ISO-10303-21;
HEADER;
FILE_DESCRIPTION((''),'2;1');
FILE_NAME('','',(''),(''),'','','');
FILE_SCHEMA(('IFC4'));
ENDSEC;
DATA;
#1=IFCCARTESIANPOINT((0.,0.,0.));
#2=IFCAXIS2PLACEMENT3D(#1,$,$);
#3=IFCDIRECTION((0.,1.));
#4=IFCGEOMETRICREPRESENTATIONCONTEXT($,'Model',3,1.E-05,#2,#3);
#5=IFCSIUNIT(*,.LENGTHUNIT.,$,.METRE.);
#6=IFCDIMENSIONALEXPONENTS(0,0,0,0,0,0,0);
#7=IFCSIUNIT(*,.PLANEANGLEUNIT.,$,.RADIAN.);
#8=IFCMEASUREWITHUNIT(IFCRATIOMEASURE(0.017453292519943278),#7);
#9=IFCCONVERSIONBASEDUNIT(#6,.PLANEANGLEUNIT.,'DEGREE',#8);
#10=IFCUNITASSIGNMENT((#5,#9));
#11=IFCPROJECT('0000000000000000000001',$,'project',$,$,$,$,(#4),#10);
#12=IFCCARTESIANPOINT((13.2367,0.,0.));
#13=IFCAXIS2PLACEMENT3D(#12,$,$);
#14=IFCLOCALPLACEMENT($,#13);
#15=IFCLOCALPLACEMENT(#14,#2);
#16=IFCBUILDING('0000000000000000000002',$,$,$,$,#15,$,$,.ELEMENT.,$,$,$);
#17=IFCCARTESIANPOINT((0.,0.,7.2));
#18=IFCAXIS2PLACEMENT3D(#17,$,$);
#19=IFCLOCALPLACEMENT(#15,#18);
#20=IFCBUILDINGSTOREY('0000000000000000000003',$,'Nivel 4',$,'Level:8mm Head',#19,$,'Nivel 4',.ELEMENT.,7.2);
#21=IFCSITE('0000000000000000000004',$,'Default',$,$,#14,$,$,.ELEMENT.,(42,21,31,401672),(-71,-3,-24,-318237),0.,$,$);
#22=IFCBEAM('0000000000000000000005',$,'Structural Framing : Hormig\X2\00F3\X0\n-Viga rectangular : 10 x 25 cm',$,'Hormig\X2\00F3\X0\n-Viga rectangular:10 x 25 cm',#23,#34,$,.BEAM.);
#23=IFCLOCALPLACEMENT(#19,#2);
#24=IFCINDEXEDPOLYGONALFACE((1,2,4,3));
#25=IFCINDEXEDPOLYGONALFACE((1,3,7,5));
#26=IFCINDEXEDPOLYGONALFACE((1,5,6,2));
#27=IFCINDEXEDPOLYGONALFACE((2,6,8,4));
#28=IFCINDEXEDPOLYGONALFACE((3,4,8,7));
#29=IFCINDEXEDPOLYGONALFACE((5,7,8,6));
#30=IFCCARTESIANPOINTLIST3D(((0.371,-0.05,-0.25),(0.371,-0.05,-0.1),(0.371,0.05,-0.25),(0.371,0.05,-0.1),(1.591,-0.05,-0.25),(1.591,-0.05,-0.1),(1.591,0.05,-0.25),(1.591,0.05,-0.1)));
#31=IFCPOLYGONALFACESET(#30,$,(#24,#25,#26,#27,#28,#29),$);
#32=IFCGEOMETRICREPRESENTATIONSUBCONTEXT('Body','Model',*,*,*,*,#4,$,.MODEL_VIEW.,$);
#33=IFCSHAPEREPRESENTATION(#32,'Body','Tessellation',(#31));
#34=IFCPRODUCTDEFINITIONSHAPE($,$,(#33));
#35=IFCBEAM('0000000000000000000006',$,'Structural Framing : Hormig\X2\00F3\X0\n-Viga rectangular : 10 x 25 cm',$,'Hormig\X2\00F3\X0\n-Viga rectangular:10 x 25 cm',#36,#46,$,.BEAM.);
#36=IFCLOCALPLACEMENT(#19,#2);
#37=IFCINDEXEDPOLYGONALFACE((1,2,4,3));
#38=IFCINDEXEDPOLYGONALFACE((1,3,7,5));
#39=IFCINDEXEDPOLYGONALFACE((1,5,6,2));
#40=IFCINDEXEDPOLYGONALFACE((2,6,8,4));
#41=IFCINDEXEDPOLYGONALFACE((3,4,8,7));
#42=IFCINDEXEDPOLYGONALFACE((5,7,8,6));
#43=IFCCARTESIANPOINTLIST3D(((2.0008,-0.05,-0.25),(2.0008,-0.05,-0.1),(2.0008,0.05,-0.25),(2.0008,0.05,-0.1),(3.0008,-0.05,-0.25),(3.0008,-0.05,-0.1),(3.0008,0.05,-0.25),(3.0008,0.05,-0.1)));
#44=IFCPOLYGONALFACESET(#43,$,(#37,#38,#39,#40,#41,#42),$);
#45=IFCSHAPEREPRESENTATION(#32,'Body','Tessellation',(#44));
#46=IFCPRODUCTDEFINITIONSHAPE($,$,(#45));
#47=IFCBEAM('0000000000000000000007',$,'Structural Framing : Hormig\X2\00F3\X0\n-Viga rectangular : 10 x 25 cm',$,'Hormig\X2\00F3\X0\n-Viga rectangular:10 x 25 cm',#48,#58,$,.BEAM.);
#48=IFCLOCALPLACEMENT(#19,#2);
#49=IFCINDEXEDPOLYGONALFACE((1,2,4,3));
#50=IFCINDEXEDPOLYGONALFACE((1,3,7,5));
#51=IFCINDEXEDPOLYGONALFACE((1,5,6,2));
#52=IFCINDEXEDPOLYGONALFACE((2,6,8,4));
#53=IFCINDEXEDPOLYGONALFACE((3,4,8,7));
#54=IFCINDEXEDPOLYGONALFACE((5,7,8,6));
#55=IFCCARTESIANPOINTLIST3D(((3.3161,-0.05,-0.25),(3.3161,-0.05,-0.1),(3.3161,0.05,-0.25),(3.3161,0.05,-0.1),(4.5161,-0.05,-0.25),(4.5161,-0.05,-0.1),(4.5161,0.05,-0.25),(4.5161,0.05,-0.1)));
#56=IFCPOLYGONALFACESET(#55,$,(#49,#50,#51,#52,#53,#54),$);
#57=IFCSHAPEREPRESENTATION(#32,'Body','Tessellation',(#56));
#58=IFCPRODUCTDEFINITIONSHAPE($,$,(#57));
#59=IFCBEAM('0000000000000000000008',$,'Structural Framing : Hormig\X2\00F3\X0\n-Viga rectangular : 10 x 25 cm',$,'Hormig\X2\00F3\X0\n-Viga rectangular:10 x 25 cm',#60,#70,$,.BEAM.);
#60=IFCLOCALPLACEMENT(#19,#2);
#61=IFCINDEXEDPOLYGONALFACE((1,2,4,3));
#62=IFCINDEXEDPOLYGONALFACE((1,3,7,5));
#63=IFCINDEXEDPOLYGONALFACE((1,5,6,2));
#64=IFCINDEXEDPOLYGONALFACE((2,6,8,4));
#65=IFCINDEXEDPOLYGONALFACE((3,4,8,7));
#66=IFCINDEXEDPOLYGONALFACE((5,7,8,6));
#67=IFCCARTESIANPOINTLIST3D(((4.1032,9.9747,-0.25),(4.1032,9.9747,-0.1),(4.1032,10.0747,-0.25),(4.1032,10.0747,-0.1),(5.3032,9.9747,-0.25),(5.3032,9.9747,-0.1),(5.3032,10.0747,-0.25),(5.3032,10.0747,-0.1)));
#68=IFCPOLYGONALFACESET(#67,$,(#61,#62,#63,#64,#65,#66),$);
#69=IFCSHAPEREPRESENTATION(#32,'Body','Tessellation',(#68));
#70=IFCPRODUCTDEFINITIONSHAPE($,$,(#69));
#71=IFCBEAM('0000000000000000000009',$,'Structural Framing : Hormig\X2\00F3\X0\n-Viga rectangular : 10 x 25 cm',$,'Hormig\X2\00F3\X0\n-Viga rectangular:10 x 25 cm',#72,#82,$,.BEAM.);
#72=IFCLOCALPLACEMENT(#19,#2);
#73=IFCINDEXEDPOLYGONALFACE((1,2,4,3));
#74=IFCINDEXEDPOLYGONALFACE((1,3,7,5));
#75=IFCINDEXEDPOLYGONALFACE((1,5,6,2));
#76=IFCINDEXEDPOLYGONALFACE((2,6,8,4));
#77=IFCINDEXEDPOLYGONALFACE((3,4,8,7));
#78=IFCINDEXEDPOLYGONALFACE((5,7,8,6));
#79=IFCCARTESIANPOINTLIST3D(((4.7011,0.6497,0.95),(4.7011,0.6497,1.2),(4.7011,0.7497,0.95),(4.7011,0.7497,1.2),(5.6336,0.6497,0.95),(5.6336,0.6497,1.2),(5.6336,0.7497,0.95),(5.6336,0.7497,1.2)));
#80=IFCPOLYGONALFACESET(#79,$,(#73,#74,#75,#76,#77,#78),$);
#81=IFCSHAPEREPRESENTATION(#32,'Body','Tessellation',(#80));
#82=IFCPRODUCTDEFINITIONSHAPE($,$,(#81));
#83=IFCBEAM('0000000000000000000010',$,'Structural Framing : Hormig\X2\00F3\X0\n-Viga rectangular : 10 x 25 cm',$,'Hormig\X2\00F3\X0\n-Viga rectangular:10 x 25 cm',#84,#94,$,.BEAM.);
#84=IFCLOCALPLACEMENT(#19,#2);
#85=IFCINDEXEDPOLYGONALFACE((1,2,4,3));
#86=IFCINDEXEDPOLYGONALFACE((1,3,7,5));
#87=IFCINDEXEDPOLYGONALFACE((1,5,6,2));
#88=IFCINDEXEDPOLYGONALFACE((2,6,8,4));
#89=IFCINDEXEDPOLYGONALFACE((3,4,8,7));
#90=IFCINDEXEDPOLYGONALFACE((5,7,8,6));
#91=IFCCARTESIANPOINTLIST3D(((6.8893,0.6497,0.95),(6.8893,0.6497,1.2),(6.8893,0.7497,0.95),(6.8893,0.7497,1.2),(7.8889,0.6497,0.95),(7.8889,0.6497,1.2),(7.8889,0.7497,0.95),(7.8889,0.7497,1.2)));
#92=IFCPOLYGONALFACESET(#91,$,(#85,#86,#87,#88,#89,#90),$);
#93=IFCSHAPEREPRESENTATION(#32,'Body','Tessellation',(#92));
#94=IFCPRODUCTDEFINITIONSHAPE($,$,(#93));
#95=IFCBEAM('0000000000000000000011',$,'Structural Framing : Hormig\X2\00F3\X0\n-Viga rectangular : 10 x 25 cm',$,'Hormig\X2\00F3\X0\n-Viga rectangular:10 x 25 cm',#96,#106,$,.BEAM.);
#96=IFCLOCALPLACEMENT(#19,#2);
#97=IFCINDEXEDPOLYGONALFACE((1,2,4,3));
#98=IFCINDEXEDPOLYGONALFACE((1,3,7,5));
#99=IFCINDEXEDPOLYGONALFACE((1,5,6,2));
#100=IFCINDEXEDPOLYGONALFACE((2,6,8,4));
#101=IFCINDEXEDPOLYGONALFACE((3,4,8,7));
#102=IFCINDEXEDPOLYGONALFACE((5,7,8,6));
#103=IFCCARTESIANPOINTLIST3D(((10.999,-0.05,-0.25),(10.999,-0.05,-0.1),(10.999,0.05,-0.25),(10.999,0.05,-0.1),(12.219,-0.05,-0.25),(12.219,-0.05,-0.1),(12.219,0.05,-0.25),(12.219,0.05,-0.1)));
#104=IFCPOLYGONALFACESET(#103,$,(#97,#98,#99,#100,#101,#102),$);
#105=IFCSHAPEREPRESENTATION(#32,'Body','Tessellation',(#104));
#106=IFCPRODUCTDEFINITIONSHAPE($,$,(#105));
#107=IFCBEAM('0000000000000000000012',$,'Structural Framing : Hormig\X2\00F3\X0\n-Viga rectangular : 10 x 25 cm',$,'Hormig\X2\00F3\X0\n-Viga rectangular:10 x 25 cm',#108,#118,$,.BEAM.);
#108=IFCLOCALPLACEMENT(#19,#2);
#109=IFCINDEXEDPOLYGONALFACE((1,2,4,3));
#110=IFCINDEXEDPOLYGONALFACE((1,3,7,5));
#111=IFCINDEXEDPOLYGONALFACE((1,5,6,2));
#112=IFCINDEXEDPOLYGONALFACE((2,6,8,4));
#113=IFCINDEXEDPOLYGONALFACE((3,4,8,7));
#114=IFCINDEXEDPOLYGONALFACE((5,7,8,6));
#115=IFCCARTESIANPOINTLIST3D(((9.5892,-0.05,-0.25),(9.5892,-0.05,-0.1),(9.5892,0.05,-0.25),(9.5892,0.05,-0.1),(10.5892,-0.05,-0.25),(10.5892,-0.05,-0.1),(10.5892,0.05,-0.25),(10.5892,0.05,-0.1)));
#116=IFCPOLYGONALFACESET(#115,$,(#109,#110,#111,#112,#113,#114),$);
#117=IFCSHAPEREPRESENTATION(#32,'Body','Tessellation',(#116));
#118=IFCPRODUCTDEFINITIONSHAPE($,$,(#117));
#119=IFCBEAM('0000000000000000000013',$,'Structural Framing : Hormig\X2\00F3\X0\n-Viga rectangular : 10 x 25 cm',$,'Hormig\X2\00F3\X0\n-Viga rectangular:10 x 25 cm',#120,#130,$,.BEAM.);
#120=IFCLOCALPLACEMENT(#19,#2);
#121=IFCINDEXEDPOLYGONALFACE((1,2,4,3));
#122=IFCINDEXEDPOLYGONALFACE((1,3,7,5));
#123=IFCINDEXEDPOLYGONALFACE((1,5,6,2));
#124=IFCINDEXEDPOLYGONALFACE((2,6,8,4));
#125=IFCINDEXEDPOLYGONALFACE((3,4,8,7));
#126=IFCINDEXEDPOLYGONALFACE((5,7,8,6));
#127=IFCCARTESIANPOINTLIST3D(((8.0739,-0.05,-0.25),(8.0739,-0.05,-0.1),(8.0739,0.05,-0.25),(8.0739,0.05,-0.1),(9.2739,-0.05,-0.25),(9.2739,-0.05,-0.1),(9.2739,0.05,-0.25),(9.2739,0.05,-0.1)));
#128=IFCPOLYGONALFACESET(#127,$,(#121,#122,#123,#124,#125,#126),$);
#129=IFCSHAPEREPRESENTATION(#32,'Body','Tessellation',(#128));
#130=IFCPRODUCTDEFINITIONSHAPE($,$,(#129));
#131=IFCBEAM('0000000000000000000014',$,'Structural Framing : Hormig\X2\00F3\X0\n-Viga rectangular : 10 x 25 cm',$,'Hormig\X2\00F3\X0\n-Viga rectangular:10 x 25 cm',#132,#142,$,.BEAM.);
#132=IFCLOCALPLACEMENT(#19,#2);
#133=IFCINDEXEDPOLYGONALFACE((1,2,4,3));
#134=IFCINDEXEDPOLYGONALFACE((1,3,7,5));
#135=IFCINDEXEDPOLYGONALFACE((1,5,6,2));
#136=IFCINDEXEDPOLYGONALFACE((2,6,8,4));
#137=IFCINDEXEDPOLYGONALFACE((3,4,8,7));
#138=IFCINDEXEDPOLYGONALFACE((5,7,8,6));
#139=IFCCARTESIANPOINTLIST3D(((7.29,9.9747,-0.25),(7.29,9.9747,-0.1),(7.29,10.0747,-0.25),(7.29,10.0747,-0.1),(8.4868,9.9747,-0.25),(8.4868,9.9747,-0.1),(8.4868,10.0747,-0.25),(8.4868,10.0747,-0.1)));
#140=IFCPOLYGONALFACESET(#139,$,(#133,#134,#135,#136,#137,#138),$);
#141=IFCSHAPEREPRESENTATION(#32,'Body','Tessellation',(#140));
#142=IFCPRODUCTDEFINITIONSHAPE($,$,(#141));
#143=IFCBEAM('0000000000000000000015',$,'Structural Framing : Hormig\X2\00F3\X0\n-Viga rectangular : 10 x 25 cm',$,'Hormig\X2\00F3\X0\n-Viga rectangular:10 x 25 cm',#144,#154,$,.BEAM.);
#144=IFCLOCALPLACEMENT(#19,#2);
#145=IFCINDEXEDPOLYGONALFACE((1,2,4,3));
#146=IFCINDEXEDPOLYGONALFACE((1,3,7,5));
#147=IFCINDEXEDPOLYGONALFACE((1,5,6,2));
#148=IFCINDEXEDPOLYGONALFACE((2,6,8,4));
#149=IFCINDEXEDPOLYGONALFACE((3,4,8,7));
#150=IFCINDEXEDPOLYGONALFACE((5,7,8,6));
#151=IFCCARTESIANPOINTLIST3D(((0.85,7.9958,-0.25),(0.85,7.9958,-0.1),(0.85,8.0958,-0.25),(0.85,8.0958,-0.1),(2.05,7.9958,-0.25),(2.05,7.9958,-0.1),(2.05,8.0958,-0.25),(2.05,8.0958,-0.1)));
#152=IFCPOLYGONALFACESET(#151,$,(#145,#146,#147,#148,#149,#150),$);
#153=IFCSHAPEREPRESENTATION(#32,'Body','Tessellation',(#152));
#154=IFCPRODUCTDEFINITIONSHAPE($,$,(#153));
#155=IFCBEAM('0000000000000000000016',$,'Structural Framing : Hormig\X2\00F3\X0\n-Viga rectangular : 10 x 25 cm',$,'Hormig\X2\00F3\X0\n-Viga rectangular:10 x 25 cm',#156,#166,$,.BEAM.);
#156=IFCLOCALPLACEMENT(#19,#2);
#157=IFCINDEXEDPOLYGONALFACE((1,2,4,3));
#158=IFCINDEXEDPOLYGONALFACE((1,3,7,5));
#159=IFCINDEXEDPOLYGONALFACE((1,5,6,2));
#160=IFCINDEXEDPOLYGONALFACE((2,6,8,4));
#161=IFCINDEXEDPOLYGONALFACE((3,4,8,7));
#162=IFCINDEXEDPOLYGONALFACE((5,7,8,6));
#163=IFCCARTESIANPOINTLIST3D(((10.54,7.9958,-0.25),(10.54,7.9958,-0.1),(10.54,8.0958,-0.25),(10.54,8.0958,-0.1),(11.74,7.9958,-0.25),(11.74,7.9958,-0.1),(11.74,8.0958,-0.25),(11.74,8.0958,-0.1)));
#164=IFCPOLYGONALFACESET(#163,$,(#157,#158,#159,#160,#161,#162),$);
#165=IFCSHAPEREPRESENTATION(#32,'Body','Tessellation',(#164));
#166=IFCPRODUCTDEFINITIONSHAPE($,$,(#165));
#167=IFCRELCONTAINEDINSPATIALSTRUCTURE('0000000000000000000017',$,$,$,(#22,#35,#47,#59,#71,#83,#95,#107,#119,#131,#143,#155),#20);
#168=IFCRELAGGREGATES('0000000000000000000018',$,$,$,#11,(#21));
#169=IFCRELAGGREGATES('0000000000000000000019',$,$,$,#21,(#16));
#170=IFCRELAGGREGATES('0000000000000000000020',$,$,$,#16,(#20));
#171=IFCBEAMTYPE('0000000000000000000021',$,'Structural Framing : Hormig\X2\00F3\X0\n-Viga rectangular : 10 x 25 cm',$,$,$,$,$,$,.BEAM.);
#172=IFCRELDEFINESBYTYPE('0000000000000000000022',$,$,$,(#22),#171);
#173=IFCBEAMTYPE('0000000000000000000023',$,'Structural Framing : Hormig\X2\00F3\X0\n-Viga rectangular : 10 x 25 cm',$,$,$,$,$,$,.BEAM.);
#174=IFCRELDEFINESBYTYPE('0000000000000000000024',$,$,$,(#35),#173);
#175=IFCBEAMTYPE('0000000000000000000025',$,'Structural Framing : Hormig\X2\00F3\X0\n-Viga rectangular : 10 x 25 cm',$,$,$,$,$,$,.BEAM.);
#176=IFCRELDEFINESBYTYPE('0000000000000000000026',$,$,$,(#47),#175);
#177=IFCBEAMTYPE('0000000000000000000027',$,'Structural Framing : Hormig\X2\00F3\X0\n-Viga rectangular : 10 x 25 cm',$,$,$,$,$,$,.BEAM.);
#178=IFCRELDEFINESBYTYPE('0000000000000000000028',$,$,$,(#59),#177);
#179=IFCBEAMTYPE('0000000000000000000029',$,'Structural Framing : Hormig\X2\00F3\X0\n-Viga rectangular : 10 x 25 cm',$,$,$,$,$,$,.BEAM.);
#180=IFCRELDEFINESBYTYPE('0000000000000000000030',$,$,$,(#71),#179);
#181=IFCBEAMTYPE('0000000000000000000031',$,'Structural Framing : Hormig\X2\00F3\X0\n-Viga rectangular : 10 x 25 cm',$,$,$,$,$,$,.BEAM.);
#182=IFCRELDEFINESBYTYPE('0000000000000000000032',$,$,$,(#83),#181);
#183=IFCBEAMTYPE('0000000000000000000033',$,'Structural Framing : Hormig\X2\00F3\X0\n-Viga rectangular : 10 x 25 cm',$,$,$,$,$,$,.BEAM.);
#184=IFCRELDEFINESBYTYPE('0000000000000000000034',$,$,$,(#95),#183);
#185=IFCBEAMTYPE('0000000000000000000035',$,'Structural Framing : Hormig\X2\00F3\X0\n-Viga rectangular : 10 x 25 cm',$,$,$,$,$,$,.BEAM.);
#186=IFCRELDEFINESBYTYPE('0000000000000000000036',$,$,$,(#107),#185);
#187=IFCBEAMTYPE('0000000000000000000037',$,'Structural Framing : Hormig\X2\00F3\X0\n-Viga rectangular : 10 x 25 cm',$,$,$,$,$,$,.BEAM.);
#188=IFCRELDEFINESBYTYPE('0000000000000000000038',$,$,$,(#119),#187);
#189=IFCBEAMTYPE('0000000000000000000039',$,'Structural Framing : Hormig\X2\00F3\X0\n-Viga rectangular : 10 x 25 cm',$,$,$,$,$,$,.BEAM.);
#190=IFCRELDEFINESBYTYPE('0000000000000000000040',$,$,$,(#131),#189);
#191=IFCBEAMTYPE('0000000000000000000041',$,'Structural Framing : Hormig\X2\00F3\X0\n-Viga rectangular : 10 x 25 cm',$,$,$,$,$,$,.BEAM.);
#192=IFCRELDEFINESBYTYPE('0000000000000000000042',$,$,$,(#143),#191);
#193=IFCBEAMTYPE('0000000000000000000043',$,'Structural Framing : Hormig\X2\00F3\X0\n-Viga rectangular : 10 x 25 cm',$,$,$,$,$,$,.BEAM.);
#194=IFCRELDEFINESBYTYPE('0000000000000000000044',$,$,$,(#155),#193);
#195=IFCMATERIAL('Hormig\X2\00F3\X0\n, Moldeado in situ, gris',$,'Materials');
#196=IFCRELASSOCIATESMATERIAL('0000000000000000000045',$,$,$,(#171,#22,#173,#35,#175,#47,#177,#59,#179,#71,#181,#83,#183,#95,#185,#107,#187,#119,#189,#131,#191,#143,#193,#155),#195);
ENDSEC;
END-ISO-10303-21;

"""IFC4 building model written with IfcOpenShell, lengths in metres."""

from ifc_helpers import new_model, entity, si_unit, converted_unit, direction, frame, origin, place, context, subcontext, project, spatial, indexed_curve, outline, extrude, source, transform, mapped, material, type_object, type_shapes, element, save


model = new_model("IFC4")

# Units and contexts
model_context = context("Model", 3, precision=1e-05, world=origin(), true_north=direction((0.0, 1.0)))
body_context = subcontext(model_context, "Body", "Model", "MODEL_VIEW")
ifc_project = project(units=[si_unit("LENGTHUNIT", "METRE"), converted_unit("PLANEANGLEUNIT", "DEGREE", entity("IfcRatioMeasure", 0.017453292519943278), si_unit("PLANEANGLEUNIT", "RADIAN"), dimensions=[0, 0, 0, 0, 0, 0, 0])], contexts=[model_context])

# Site, building, storey
site_placement = place(None, frame((13.2367, 0.0, 0.0)))
site = spatial("IfcSite", under=ifc_project, at=site_placement, Name="Default", CompositionType="ELEMENT", RefLatitude=(42, 21, 31, 401672), RefLongitude=(-71, -3, -24, -318237), RefElevation=0.0)
building_placement = place(site_placement, origin())
building = spatial("IfcBuilding", under=site, at=building_placement, CompositionType="ELEMENT")
storey_placement = place(building_placement, frame((0.0, 0.0, 7.2)))
storey = spatial("IfcBuildingStorey", under=building, at=storey_placement, Name="Nivel 4", ObjectType="Level:8mm Head", LongName="Nivel 4", CompositionType="ELEMENT", Elevation=7.2)

# Beams
ifc_material_1 = material(Name="Hormigón, Moldeado in situ, gris", Category="Materials")
beam_type_1 = type_object("IfcBeamType", Name="Structural Framing : Hormigón-Viga rectangular : 10 x 25 cm", PredefinedType="BEAM", material=ifc_material_1)
shared_shape_1 = source(origin(), body_context, "Body", "SweptSolid", [
    extrude(outline(indexed_curve([(-0.075, -0.05), (0.075, -0.05), (0.075, 0.05), (-0.075, 0.05), (-0.075, -0.05)], self_intersect=False)), frame((0.371, 0.0, 7.025), z_axis=(1.0, 0.0, 0.0), x_axis=(0.0, 0.0, -1.0)), (0.0, 0.0, 1.0), 1.22),
])
type_shapes(beam_type_1, [shared_shape_1])
beam_1_placement = place(storey_placement, frame((0.0, 0.0, -7.2)))
element("IfcBeam", 1, at=beam_1_placement, inside=storey, type_object=beam_type_1, material=ifc_material_1, Name="Structural Framing : Hormigón-Viga rectangular : 10 x 25 cm", ObjectType="Hormigón-Viga rectangular:10 x 25 cm", PredefinedType="BEAM", context=body_context, shape_type="MappedRepresentation", body=[
    mapped(shared_shape_1, transform((0.0, 0.0, 0.0), scale=1.0)),
])
beam_type_2 = type_object("IfcBeamType", Name="Structural Framing : Hormigón-Viga rectangular : 10 x 25 cm", PredefinedType="BEAM", material=ifc_material_1)
shared_shape_2 = source(origin(), body_context, "Body", "SweptSolid", [
    extrude(outline(indexed_curve([(-0.075, -0.05), (0.075, -0.05), (0.075, 0.05), (-0.075, 0.05), (-0.075, -0.05)], self_intersect=False)), frame((2.0008, 0.0, 7.025), z_axis=(1.0, 0.0, 0.0), x_axis=(0.0, 0.0, -1.0)), (0.0, 0.0, 1.0), 1.0),
])
type_shapes(beam_type_2, [shared_shape_2])
beam_2_placement = place(storey_placement, frame((0.0, 0.0, -7.2)))
element("IfcBeam", 2, at=beam_2_placement, inside=storey, type_object=beam_type_2, material=ifc_material_1, Name="Structural Framing : Hormigón-Viga rectangular : 10 x 25 cm", ObjectType="Hormigón-Viga rectangular:10 x 25 cm", PredefinedType="BEAM", context=body_context, shape_type="MappedRepresentation", body=[
    mapped(shared_shape_2, transform((0.0, 0.0, 0.0), scale=1.0)),
])
beam_type_3 = type_object("IfcBeamType", Name="Structural Framing : Hormigón-Viga rectangular : 10 x 25 cm", PredefinedType="BEAM", material=ifc_material_1)
shared_shape_3 = source(origin(), body_context, "Body", "SweptSolid", [
    extrude(outline(indexed_curve([(-0.075, -0.05), (0.075, -0.05), (0.075, 0.05), (-0.075, 0.05), (-0.075, -0.05)], self_intersect=False)), frame((3.3161, 0.0, 7.025), z_axis=(1.0, 0.0, 0.0), x_axis=(0.0, 0.0, -1.0)), (0.0, 0.0, 1.0), 1.2),
])
type_shapes(beam_type_3, [shared_shape_3])
beam_3_placement = place(storey_placement, frame((0.0, 0.0, -7.2)))
element("IfcBeam", 3, at=beam_3_placement, inside=storey, type_object=beam_type_3, material=ifc_material_1, Name="Structural Framing : Hormigón-Viga rectangular : 10 x 25 cm", ObjectType="Hormigón-Viga rectangular:10 x 25 cm", PredefinedType="BEAM", context=body_context, shape_type="MappedRepresentation", body=[
    mapped(shared_shape_3, transform((0.0, 0.0, 0.0), scale=1.0)),
])
beam_type_4 = type_object("IfcBeamType", Name="Structural Framing : Hormigón-Viga rectangular : 10 x 25 cm", PredefinedType="BEAM", material=ifc_material_1)
shared_shape_4 = source(origin(), body_context, "Body", "SweptSolid", [
    extrude(outline(indexed_curve([(-0.075, -0.05), (0.075, -0.05), (0.075, 0.05), (-0.075, 0.05), (-0.075, -0.05)], self_intersect=False)), frame((5.3032, 10.0247, 7.025), z_axis=(-1.0, 0.0, 0.0), x_axis=(0.0, 0.0, -1.0)), (0.0, 0.0, 1.0), 1.2),
])
type_shapes(beam_type_4, [shared_shape_4])
beam_4_placement = place(storey_placement, frame((0.0, 0.0, -7.2)))
element("IfcBeam", 4, at=beam_4_placement, inside=storey, type_object=beam_type_4, material=ifc_material_1, Name="Structural Framing : Hormigón-Viga rectangular : 10 x 25 cm", ObjectType="Hormigón-Viga rectangular:10 x 25 cm", PredefinedType="BEAM", context=body_context, shape_type="MappedRepresentation", body=[
    mapped(shared_shape_4, transform((0.0, 0.0, 0.0), scale=1.0)),
])
beam_type_5 = type_object("IfcBeamType", Name="Structural Framing : Hormigón-Viga rectangular : 10 x 25 cm", PredefinedType="BEAM", material=ifc_material_1)
shared_shape_5 = source(origin(), body_context, "Body", "SweptSolid", [
    extrude(outline(indexed_curve([(-0.125, -0.05), (0.125, -0.05), (0.125, 0.05), (-0.125, 0.05), (-0.125, -0.05)], self_intersect=False)), frame((5.6336, 0.6997, 8.275), z_axis=(-1.0, 0.0, 0.0), x_axis=(0.0, 0.0, -1.0)), (0.0, 0.0, 1.0), 0.9325),
])
type_shapes(beam_type_5, [shared_shape_5])
beam_5_placement = place(storey_placement, frame((0.0, 0.0, -7.2)))
element("IfcBeam", 5, at=beam_5_placement, inside=storey, type_object=beam_type_5, material=ifc_material_1, Name="Structural Framing : Hormigón-Viga rectangular : 10 x 25 cm", ObjectType="Hormigón-Viga rectangular:10 x 25 cm", PredefinedType="BEAM", context=body_context, shape_type="MappedRepresentation", body=[
    mapped(shared_shape_5, transform((0.0, 0.0, 0.0), scale=1.0)),
])
beam_type_6 = type_object("IfcBeamType", Name="Structural Framing : Hormigón-Viga rectangular : 10 x 25 cm", PredefinedType="BEAM", material=ifc_material_1)
shared_shape_6 = source(origin(), body_context, "Body", "SweptSolid", [
    extrude(outline(indexed_curve([(-0.125, -0.05), (0.125, -0.05), (0.125, 0.05), (-0.125, 0.05), (-0.125, -0.05)], self_intersect=False)), frame((7.8889, 0.6997, 8.275), z_axis=(-1.0, 0.0, 0.0), x_axis=(0.0, 0.0, -1.0)), (0.0, 0.0, 1.0), 0.9996),
])
type_shapes(beam_type_6, [shared_shape_6])
beam_6_placement = place(storey_placement, frame((0.0, 0.0, -7.2)))
element("IfcBeam", 6, at=beam_6_placement, inside=storey, type_object=beam_type_6, material=ifc_material_1, Name="Structural Framing : Hormigón-Viga rectangular : 10 x 25 cm", ObjectType="Hormigón-Viga rectangular:10 x 25 cm", PredefinedType="BEAM", context=body_context, shape_type="MappedRepresentation", body=[
    mapped(shared_shape_6, transform((0.0, 0.0, 0.0), scale=1.0)),
])
beam_type_7 = type_object("IfcBeamType", Name="Structural Framing : Hormigón-Viga rectangular : 10 x 25 cm", PredefinedType="BEAM", material=ifc_material_1)
shared_shape_7 = source(origin(), body_context, "Body", "SweptSolid", [
    extrude(outline(indexed_curve([(-0.075, -0.05), (0.075, -0.05), (0.075, 0.05), (-0.075, 0.05), (-0.075, -0.05)], self_intersect=False)), frame((12.219, 0.0, 7.025), z_axis=(-1.0, 0.0, 0.0), x_axis=(0.0, 0.0, -1.0)), (0.0, 0.0, 1.0), 1.22),
])
type_shapes(beam_type_7, [shared_shape_7])
beam_7_placement = place(storey_placement, frame((0.0, 0.0, -7.2)))
element("IfcBeam", 7, at=beam_7_placement, inside=storey, type_object=beam_type_7, material=ifc_material_1, Name="Structural Framing : Hormigón-Viga rectangular : 10 x 25 cm", ObjectType="Hormigón-Viga rectangular:10 x 25 cm", PredefinedType="BEAM", context=body_context, shape_type="MappedRepresentation", body=[
    mapped(shared_shape_7, transform((0.0, 0.0, 0.0), scale=1.0)),
])
beam_type_8 = type_object("IfcBeamType", Name="Structural Framing : Hormigón-Viga rectangular : 10 x 25 cm", PredefinedType="BEAM", material=ifc_material_1)
shared_shape_8 = source(origin(), body_context, "Body", "SweptSolid", [
    extrude(outline(indexed_curve([(-0.075, -0.05), (0.075, -0.05), (0.075, 0.05), (-0.075, 0.05), (-0.075, -0.05)], self_intersect=False)), frame((10.5892, 0.0, 7.025), z_axis=(-1.0, 0.0, 0.0), x_axis=(0.0, 0.0, -1.0)), (0.0, 0.0, 1.0), 1.0),
])
type_shapes(beam_type_8, [shared_shape_8])
beam_8_placement = place(storey_placement, frame((0.0, 0.0, -7.2)))
element("IfcBeam", 8, at=beam_8_placement, inside=storey, type_object=beam_type_8, material=ifc_material_1, Name="Structural Framing : Hormigón-Viga rectangular : 10 x 25 cm", ObjectType="Hormigón-Viga rectangular:10 x 25 cm", PredefinedType="BEAM", context=body_context, shape_type="MappedRepresentation", body=[
    mapped(shared_shape_8, transform((0.0, 0.0, 0.0), scale=1.0)),
])
beam_type_9 = type_object("IfcBeamType", Name="Structural Framing : Hormigón-Viga rectangular : 10 x 25 cm", PredefinedType="BEAM", material=ifc_material_1)
shared_shape_9 = source(origin(), body_context, "Body", "SweptSolid", [
    extrude(outline(indexed_curve([(-0.075, -0.05), (0.075, -0.05), (0.075, 0.05), (-0.075, 0.05), (-0.075, -0.05)], self_intersect=False)), frame((9.2739, 0.0, 7.025), z_axis=(-1.0, 0.0, 0.0), x_axis=(0.0, 0.0, -1.0)), (0.0, 0.0, 1.0), 1.2),
])
type_shapes(beam_type_9, [shared_shape_9])
beam_9_placement = place(storey_placement, frame((0.0, 0.0, -7.2)))
element("IfcBeam", 9, at=beam_9_placement, inside=storey, type_object=beam_type_9, material=ifc_material_1, Name="Structural Framing : Hormigón-Viga rectangular : 10 x 25 cm", ObjectType="Hormigón-Viga rectangular:10 x 25 cm", PredefinedType="BEAM", context=body_context, shape_type="MappedRepresentation", body=[
    mapped(shared_shape_9, transform((0.0, 0.0, 0.0), scale=1.0)),
])
beam_type_10 = type_object("IfcBeamType", Name="Structural Framing : Hormigón-Viga rectangular : 10 x 25 cm", PredefinedType="BEAM", material=ifc_material_1)
shared_shape_10 = source(origin(), body_context, "Body", "SweptSolid", [
    extrude(outline(indexed_curve([(-0.075, -0.05), (0.075, -0.05), (0.075, 0.05), (-0.075, 0.05), (-0.075, -0.05)], self_intersect=False)), frame((7.29, 10.0247, 7.025), z_axis=(1.0, 0.0, 0.0), x_axis=(0.0, 0.0, -1.0)), (0.0, 0.0, 1.0), 1.1968),
])
type_shapes(beam_type_10, [shared_shape_10])
beam_10_placement = place(storey_placement, frame((0.0, 0.0, -7.2)))
element("IfcBeam", 10, at=beam_10_placement, inside=storey, type_object=beam_type_10, material=ifc_material_1, Name="Structural Framing : Hormigón-Viga rectangular : 10 x 25 cm", ObjectType="Hormigón-Viga rectangular:10 x 25 cm", PredefinedType="BEAM", context=body_context, shape_type="MappedRepresentation", body=[
    mapped(shared_shape_10, transform((0.0, 0.0, 0.0), scale=1.0)),
])
beam_type_11 = type_object("IfcBeamType", Name="Structural Framing : Hormigón-Viga rectangular : 10 x 25 cm", PredefinedType="BEAM", material=ifc_material_1)
shared_shape_11 = source(origin(), body_context, "Body", "SweptSolid", [
    extrude(outline(indexed_curve([(-0.075, -0.05), (0.075, -0.05), (0.075, 0.05), (-0.075, 0.05), (-0.075, -0.05)], self_intersect=False)), frame((2.05, 8.0458, 7.025), z_axis=(-1.0, 0.0, 0.0), x_axis=(0.0, 0.0, -1.0)), (0.0, 0.0, 1.0), 1.2),
])
type_shapes(beam_type_11, [shared_shape_11])
beam_11_placement = place(storey_placement, frame((0.0, 0.0, -7.2)))
element("IfcBeam", 11, at=beam_11_placement, inside=storey, type_object=beam_type_11, material=ifc_material_1, Name="Structural Framing : Hormigón-Viga rectangular : 10 x 25 cm", ObjectType="Hormigón-Viga rectangular:10 x 25 cm", PredefinedType="BEAM", context=body_context, shape_type="MappedRepresentation", body=[
    mapped(shared_shape_11, transform((0.0, 0.0, 0.0), scale=1.0)),
])
beam_type_12 = type_object("IfcBeamType", Name="Structural Framing : Hormigón-Viga rectangular : 10 x 25 cm", PredefinedType="BEAM", material=ifc_material_1)
shared_shape_12 = source(origin(), body_context, "Body", "SweptSolid", [
    extrude(outline(indexed_curve([(-0.075, -0.05), (0.075, -0.05), (0.075, 0.05), (-0.075, 0.05), (-0.075, -0.05)], self_intersect=False)), frame((10.54, 8.0458, 7.025), z_axis=(1.0, 0.0, 0.0), x_axis=(0.0, 0.0, -1.0)), (0.0, 0.0, 1.0), 1.2),
])
type_shapes(beam_type_12, [shared_shape_12])
beam_12_placement = place(storey_placement, frame((0.0, 0.0, -7.2)))
element("IfcBeam", 12, at=beam_12_placement, inside=storey, type_object=beam_type_12, material=ifc_material_1, Name="Structural Framing : Hormigón-Viga rectangular : 10 x 25 cm", ObjectType="Hormigón-Viga rectangular:10 x 25 cm", PredefinedType="BEAM", context=body_context, shape_type="MappedRepresentation", body=[
    mapped(shared_shape_12, transform((0.0, 0.0, 0.0), scale=1.0)),
])

save(model, "model.ifc")
